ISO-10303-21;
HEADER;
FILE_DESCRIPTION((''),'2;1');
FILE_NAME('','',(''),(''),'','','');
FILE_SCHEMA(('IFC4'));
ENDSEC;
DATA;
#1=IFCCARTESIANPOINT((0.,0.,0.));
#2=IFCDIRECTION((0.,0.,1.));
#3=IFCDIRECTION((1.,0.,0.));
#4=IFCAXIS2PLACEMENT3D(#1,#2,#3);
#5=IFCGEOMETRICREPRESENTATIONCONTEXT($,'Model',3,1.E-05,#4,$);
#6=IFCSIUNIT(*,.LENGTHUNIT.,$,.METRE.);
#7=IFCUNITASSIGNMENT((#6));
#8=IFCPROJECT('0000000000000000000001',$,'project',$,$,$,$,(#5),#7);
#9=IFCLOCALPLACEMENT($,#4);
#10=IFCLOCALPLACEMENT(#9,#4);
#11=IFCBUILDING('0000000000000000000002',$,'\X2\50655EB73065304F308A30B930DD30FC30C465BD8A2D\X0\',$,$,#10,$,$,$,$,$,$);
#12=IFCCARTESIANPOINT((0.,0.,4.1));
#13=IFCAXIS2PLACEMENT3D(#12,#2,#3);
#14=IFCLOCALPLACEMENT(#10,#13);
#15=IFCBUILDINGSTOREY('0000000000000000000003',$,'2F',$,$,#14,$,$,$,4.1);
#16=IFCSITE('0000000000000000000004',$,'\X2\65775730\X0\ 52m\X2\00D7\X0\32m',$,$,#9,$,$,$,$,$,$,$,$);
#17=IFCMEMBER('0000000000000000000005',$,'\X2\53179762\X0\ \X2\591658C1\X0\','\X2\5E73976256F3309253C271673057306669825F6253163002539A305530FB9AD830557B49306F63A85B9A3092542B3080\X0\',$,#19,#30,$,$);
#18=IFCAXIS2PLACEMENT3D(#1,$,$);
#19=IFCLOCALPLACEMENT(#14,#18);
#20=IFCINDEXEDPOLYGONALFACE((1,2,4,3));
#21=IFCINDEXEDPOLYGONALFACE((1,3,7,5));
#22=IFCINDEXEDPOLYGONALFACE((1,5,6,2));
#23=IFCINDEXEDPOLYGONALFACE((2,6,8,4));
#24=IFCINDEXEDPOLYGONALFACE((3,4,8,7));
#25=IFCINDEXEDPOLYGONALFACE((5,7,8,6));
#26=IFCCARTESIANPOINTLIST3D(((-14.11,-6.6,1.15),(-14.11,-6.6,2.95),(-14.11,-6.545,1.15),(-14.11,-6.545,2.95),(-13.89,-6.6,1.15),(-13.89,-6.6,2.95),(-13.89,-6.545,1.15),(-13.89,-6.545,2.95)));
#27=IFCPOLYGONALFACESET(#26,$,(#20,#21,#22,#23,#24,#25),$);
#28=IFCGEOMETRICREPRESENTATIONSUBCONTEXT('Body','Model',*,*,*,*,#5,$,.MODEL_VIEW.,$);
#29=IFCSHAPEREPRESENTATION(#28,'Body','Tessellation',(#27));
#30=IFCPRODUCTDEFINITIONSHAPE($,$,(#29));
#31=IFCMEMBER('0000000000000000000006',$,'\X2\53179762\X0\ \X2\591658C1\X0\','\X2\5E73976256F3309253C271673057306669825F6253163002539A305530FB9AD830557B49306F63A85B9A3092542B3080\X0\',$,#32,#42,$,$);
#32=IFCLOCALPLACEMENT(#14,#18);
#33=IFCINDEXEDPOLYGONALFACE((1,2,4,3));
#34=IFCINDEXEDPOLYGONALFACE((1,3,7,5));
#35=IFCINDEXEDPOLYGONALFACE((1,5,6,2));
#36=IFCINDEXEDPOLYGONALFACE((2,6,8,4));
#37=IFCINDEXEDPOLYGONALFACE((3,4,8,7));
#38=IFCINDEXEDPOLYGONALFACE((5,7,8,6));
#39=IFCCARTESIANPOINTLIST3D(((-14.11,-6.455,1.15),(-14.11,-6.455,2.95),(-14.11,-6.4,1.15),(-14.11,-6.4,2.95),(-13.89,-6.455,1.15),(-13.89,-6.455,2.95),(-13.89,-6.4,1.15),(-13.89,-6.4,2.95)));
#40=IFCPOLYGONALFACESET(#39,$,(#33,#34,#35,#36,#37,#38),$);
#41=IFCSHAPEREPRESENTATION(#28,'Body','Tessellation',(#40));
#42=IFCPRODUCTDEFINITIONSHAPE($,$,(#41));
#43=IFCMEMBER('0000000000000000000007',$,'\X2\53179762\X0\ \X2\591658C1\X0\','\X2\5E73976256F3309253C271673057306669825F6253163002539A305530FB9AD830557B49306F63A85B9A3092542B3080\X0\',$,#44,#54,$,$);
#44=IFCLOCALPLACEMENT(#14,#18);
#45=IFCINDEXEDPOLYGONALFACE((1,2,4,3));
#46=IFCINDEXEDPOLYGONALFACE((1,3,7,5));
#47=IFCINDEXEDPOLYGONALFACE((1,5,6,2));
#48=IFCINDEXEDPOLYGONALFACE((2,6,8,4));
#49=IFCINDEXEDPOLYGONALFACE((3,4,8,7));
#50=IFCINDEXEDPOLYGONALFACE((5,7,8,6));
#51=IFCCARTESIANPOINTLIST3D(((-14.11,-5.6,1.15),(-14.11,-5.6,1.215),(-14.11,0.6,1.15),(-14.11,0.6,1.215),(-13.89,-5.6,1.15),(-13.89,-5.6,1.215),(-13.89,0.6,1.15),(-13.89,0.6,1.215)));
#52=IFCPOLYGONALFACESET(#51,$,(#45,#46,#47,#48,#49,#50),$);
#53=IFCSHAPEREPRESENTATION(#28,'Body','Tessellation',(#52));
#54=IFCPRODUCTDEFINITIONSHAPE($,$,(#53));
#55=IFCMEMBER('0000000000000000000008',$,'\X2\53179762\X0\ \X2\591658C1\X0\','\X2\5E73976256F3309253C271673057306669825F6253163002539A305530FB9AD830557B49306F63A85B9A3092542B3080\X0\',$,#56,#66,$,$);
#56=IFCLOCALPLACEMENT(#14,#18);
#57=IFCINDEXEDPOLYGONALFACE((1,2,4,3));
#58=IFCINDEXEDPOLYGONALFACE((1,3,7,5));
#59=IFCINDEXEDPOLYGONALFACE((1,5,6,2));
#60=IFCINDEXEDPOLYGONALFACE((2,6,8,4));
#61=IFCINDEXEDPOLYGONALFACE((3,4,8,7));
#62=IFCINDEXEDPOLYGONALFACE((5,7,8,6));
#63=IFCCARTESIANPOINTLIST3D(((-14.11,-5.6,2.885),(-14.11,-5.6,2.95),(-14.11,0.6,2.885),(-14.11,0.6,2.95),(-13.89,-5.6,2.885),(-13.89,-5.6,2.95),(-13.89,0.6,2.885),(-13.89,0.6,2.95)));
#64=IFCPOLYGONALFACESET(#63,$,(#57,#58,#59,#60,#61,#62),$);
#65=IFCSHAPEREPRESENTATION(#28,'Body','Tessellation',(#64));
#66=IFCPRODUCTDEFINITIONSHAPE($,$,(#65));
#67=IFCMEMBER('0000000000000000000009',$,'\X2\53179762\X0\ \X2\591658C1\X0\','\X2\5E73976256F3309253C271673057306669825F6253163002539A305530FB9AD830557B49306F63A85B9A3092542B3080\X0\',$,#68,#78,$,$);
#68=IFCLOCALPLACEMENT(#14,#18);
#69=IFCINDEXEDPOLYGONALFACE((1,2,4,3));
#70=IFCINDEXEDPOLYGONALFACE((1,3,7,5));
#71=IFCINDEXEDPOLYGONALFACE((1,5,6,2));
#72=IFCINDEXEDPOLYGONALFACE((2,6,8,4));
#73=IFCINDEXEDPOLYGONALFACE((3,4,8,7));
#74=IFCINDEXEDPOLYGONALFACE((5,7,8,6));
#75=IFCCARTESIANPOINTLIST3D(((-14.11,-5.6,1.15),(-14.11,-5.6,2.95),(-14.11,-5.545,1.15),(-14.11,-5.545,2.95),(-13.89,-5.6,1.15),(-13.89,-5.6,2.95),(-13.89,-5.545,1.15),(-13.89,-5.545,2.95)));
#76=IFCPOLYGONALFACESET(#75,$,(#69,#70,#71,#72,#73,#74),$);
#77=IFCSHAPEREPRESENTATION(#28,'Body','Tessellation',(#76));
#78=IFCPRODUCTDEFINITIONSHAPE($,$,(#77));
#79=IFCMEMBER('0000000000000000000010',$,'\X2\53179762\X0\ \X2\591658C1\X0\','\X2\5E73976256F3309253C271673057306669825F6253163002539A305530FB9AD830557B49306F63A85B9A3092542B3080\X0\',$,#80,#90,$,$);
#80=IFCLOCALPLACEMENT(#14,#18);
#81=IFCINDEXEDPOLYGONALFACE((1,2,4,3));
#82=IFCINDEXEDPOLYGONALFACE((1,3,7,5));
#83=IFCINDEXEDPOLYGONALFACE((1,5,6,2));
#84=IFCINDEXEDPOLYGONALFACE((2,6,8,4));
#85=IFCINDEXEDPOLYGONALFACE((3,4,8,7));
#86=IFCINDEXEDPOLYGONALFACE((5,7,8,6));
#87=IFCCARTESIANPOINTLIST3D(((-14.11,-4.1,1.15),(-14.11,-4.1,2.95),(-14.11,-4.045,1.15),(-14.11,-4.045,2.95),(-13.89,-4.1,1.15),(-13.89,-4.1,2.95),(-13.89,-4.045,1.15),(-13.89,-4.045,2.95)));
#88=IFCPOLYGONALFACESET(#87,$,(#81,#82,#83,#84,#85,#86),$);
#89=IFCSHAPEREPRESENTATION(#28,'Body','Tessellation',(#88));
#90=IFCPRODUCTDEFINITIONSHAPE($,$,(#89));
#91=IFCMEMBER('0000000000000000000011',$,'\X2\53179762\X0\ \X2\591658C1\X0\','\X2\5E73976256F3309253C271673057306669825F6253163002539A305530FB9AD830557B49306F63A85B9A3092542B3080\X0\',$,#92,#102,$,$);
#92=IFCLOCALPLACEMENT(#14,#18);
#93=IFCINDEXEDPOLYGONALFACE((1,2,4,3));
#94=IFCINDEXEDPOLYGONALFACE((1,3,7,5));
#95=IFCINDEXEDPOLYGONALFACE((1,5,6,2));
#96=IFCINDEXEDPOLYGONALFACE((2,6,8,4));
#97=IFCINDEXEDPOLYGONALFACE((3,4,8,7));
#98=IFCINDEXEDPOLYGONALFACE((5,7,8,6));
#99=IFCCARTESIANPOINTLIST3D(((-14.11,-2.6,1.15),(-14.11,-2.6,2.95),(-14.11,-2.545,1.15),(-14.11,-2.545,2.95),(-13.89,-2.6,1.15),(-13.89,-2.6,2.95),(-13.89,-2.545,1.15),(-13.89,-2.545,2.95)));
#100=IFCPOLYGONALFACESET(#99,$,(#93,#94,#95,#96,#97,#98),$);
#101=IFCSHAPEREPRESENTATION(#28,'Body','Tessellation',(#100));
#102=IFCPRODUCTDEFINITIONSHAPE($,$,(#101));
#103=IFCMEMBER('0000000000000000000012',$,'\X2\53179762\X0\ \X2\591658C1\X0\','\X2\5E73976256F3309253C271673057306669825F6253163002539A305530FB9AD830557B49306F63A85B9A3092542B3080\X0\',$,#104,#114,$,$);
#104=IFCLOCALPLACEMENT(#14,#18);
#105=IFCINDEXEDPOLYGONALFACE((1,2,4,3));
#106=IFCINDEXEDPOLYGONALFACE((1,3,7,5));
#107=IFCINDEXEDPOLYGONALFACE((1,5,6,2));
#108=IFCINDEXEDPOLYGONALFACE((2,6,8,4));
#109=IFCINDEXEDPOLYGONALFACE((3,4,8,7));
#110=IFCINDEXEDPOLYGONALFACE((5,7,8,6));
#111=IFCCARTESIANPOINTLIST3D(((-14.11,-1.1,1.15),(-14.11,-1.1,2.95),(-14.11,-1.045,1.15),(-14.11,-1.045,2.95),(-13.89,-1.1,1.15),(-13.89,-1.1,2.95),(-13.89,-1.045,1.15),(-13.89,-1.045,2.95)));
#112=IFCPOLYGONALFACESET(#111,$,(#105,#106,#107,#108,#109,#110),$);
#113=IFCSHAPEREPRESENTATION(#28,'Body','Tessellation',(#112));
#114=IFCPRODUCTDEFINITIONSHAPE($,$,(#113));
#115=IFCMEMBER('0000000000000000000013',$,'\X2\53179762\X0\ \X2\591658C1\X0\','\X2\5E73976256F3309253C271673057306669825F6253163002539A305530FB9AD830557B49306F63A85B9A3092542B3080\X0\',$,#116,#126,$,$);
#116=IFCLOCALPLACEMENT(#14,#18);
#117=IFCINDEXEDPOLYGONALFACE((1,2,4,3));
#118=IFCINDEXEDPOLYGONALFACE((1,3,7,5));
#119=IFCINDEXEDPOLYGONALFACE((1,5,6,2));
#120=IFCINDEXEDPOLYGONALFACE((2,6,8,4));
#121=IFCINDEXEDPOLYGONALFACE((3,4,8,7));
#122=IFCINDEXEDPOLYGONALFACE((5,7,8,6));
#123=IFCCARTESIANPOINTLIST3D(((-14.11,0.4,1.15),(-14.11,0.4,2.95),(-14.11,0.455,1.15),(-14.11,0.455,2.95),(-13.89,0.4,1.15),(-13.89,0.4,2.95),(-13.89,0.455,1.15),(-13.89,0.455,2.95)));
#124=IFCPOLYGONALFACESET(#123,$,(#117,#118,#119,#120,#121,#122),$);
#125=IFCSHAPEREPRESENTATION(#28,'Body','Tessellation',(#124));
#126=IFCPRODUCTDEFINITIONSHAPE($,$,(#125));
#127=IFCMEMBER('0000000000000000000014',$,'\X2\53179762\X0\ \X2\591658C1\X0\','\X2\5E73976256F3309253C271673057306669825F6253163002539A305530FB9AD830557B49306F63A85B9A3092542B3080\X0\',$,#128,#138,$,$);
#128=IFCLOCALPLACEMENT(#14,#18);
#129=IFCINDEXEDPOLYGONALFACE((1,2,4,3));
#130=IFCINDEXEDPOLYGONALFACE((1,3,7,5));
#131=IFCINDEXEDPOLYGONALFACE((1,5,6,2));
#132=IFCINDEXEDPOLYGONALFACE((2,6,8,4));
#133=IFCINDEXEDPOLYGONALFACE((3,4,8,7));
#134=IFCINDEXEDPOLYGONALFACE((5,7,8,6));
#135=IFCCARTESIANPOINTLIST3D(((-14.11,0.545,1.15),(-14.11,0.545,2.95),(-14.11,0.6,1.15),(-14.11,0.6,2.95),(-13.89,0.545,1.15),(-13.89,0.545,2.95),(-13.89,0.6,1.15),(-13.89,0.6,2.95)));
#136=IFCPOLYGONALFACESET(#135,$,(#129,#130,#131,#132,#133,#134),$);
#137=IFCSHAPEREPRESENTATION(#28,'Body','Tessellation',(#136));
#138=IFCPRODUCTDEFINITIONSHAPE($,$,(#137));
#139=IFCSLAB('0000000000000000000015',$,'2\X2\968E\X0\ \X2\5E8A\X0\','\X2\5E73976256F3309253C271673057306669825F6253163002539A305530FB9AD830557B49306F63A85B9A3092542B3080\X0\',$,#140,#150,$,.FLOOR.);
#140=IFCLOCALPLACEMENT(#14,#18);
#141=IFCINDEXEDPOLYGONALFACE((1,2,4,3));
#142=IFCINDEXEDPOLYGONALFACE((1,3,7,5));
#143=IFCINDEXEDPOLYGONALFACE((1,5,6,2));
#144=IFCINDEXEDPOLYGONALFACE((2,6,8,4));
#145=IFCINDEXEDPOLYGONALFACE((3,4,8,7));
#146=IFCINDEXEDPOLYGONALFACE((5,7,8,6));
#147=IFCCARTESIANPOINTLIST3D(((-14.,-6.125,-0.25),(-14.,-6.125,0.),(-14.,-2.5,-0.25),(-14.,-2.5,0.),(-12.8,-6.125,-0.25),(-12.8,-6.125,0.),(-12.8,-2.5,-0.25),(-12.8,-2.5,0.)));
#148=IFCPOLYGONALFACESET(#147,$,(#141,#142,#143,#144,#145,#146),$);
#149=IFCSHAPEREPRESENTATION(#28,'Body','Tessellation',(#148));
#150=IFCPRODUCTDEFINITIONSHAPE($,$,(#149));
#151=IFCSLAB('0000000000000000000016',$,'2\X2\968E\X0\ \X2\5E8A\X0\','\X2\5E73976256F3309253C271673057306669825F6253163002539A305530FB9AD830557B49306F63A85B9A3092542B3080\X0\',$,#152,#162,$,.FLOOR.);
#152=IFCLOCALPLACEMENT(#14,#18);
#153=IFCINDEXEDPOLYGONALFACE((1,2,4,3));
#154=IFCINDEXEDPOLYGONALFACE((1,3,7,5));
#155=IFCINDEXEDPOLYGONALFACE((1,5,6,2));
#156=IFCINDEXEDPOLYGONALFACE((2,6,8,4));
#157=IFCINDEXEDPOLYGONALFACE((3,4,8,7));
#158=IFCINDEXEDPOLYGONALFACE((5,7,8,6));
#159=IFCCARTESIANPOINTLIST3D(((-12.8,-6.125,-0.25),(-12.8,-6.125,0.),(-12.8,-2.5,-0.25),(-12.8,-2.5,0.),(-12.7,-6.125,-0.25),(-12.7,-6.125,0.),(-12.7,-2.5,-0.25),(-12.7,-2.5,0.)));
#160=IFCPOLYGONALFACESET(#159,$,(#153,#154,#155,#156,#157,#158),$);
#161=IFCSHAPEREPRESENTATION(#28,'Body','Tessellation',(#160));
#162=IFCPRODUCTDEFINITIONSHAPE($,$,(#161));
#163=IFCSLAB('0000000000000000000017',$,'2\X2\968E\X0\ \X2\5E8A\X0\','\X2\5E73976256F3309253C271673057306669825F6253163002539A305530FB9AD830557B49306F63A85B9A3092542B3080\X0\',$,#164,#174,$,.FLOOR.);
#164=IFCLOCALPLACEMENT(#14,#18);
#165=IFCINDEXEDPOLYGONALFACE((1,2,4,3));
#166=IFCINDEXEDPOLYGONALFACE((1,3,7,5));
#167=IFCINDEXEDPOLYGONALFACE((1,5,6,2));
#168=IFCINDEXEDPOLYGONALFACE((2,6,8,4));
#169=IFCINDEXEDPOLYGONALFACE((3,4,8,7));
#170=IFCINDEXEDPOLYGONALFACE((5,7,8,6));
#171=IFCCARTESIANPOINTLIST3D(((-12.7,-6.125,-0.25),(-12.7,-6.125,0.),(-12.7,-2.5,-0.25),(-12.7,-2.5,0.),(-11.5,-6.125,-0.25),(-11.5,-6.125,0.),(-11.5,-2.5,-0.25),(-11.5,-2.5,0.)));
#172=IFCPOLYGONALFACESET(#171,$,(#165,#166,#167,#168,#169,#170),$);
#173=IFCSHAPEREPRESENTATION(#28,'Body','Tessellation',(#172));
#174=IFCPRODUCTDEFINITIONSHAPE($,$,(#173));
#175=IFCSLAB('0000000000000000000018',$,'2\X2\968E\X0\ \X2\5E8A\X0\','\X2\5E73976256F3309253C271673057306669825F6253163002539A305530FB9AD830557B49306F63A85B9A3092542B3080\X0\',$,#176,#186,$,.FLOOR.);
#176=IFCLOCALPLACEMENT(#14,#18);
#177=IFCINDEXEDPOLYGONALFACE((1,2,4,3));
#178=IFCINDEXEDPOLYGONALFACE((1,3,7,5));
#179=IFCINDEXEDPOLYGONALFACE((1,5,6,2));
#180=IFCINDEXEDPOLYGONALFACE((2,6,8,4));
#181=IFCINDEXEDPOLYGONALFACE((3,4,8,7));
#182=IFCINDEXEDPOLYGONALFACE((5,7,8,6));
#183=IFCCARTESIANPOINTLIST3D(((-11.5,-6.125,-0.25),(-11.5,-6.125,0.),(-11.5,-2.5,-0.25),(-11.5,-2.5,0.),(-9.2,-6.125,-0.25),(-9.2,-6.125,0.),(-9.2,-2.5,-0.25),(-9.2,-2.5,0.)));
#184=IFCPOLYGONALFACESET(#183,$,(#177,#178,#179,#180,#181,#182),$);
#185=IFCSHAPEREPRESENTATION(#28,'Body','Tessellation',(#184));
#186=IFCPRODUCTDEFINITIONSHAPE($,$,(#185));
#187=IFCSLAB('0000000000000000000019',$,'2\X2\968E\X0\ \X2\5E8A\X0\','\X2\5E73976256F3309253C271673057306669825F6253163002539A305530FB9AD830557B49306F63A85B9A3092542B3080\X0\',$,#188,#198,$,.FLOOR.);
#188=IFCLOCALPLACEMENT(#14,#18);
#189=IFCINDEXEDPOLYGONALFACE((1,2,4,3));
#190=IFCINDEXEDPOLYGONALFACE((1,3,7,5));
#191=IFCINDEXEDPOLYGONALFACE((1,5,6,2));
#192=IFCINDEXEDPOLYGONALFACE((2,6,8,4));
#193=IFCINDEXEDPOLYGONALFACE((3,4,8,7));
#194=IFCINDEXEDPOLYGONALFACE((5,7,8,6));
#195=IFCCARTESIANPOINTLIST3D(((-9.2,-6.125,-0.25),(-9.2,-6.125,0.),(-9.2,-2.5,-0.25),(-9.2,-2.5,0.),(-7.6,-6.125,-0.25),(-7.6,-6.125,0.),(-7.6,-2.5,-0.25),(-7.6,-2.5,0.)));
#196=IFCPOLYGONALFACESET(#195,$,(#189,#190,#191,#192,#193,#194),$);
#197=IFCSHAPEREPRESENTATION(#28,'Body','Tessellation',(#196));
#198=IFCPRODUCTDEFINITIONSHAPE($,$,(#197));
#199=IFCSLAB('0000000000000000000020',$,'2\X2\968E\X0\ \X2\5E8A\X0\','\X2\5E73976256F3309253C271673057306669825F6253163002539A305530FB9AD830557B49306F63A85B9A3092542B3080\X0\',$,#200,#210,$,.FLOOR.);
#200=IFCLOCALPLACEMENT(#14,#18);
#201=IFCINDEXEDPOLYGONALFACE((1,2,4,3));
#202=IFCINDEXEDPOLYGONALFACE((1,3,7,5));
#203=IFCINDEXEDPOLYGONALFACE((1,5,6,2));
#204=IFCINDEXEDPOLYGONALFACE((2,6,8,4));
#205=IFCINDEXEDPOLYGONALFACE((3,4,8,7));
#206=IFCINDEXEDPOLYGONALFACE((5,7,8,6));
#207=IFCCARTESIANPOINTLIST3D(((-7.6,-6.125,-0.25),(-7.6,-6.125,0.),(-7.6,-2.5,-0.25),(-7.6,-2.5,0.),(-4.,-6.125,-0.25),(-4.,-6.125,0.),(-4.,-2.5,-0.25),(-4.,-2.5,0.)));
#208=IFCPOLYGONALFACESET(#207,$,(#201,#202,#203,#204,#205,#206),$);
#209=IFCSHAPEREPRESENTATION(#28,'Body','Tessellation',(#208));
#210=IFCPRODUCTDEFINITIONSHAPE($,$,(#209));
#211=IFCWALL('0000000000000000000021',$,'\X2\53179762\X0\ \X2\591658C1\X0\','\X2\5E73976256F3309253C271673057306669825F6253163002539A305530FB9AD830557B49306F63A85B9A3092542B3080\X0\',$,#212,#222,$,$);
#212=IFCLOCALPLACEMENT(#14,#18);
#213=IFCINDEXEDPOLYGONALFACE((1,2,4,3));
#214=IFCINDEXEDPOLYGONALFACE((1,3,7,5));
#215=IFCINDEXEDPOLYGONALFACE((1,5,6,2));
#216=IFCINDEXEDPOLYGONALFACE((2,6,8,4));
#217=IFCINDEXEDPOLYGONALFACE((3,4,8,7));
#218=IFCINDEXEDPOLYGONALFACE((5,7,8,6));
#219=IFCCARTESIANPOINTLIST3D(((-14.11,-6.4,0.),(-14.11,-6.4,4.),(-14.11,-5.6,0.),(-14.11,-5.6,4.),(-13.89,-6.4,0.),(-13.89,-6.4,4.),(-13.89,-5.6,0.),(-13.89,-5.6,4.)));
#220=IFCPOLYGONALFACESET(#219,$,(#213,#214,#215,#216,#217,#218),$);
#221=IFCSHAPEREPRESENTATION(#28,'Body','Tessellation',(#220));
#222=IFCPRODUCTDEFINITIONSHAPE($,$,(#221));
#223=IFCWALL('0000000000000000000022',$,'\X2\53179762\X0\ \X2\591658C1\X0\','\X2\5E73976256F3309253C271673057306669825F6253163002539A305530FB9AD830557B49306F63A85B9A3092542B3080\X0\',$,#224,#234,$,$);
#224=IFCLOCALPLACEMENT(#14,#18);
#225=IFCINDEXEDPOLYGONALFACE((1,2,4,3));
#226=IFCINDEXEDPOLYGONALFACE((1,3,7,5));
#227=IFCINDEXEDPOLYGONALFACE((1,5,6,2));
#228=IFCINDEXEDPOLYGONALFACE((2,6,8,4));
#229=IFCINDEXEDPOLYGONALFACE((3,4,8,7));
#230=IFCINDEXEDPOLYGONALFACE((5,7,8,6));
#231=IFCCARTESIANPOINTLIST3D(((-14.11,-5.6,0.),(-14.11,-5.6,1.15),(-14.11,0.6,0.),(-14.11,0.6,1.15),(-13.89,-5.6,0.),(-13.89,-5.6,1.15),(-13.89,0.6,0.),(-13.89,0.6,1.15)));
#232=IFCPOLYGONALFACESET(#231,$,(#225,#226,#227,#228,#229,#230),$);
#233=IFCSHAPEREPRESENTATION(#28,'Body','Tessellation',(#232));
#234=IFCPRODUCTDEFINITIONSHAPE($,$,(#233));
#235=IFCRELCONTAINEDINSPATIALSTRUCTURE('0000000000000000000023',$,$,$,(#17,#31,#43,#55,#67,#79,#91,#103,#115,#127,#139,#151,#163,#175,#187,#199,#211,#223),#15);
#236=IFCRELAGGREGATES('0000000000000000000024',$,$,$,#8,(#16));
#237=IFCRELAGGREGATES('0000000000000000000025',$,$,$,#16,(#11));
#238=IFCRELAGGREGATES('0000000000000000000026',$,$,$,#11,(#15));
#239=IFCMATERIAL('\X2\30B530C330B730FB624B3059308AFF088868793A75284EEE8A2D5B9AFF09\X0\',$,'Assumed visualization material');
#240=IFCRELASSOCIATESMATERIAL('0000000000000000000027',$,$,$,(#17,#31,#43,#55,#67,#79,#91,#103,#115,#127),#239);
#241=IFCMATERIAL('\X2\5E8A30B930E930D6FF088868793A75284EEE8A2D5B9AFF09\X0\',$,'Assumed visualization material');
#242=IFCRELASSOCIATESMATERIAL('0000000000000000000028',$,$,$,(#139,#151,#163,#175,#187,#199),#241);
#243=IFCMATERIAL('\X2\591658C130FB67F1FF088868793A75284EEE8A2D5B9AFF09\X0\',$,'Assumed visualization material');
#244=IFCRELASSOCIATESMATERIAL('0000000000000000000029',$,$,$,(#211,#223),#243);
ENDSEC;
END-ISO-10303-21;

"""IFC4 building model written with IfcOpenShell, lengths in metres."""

from ifc_helpers import new_model, si_unit, frame, origin_with_axes, place, context, subcontext, project, spatial, rectangle, extrude, material, element, save


model = new_model("IFC4")

# Units and contexts
model_context = context("Model", 3, precision=1e-05, world=origin_with_axes())
body_context = subcontext(model_context, "Body", "Model", "MODEL_VIEW")
ifc_project = project(units=[si_unit("LENGTHUNIT", "METRE")], contexts=[model_context])

# Site, building, storey
site_placement = place(None, origin_with_axes())
site = spatial("IfcSite", under=ifc_project, at=site_placement, Name="敷地 52m×32m")
building_placement = place(site_placement, origin_with_axes())
building = spatial("IfcBuilding", under=site, at=building_placement, Name="健康づくりスポーツ施設")
storey_placement = place(building_placement, frame((0.0, 0.0, 4.1), z_axis=(0.0, 0.0, 1.0), x_axis=(1.0, 0.0, 0.0)))
storey = spatial("IfcBuildingStorey", under=building, at=storey_placement, Name="2F", Elevation=4.1)

# Members
ifc_material_1 = material(Name="サッシ・手すり（表示用仮設定）", Category="Assumed visualization material")
for number, where, z_axis, x_axis, name in (
    (1, (-14.0, -6.5725, 1.15), (0.0, 0.0, 1.0), (1.0, 0.0, 0.0), "北面 外壁"),
    (2, (-14.0, -6.4275, 1.15), (0.0, 0.0, 1.0), (1.0, 0.0, 0.0), "北面 外壁"),
):
    element("IfcMember", number, at=place(storey_placement, frame(where, z_axis=z_axis, x_axis=x_axis)), inside=storey, material=ifc_material_1, Name=name, Description="平面図を参照して概形化。厚さ・高さ等は推定を含む", context=body_context, shape_type="SweptSolid", body=[
        extrude(rectangle(XDim=0.22, YDim=0.055), origin_with_axes(), (0.0, 0.0, 1.0), 1.8),
    ])
for number, where, z_axis, x_axis, name in (
    (3, (-14.0, -2.5, 1.15), (0.0, 0.0, 1.0), (1.0, 0.0, 0.0), "北面 外壁"),
    (4, (-14.0, -2.5, 2.885), (0.0, 0.0, 1.0), (1.0, 0.0, 0.0), "北面 外壁"),
):
    element("IfcMember", number, at=place(storey_placement, frame(where, z_axis=z_axis, x_axis=x_axis)), inside=storey, material=ifc_material_1, Name=name, Description="平面図を参照して概形化。厚さ・高さ等は推定を含む", context=body_context, shape_type="SweptSolid", body=[
        extrude(rectangle(XDim=0.22, YDim=6.2), origin_with_axes(), (0.0, 0.0, 1.0), 0.065),
    ])
for number, where, z_axis, x_axis, name in (
    (5, (-14.0, -5.5725, 1.15), (0.0, 0.0, 1.0), (1.0, 0.0, 0.0), "北面 外壁"),
    (6, (-14.0, -4.0725, 1.15), (0.0, 0.0, 1.0), (1.0, 0.0, 0.0), "北面 外壁"),
    (7, (-14.0, -2.5725, 1.15), (0.0, 0.0, 1.0), (1.0, 0.0, 0.0), "北面 外壁"),
    (8, (-14.0, -1.0725, 1.15), (0.0, 0.0, 1.0), (1.0, 0.0, 0.0), "北面 外壁"),
    (9, (-14.0, 0.4275, 1.15), (0.0, 0.0, 1.0), (1.0, 0.0, 0.0), "北面 外壁"),
    (10, (-14.0, 0.5725, 1.15), (0.0, 0.0, 1.0), (1.0, 0.0, 0.0), "北面 外壁"),
):
    element("IfcMember", number, at=place(storey_placement, frame(where, z_axis=z_axis, x_axis=x_axis)), inside=storey, material=ifc_material_1, Name=name, Description="平面図を参照して概形化。厚さ・高さ等は推定を含む", context=body_context, shape_type="SweptSolid", body=[
        extrude(rectangle(XDim=0.22, YDim=0.055), origin_with_axes(), (0.0, 0.0, 1.0), 1.8),
    ])

# Slabs
ifc_material_2 = material(Name="床スラブ（表示用仮設定）", Category="Assumed visualization material")
slab_1_placement = place(storey_placement, frame((-13.4, -4.3125, -0.25), z_axis=(0.0, 0.0, 1.0), x_axis=(1.0, 0.0, 0.0)))
element("IfcSlab", 11, at=slab_1_placement, inside=storey, material=ifc_material_2, Name="2階 床", Description="平面図を参照して概形化。厚さ・高さ等は推定を含む", PredefinedType="FLOOR", context=body_context, shape_type="SweptSolid", body=[
    extrude(rectangle(XDim=1.2, YDim=3.625), origin_with_axes(), (0.0, 0.0, 1.0), 0.25),
])
slab_2_placement = place(storey_placement, frame((-12.75, -4.3125, -0.25), z_axis=(0.0, 0.0, 1.0), x_axis=(1.0, 0.0, 0.0)))
element("IfcSlab", 12, at=slab_2_placement, inside=storey, material=ifc_material_2, Name="2階 床", Description="平面図を参照して概形化。厚さ・高さ等は推定を含む", PredefinedType="FLOOR", context=body_context, shape_type="SweptSolid", body=[
    extrude(rectangle(XDim=0.1, YDim=3.625), origin_with_axes(), (0.0, 0.0, 1.0), 0.25),
])
slab_3_placement = place(storey_placement, frame((-12.1, -4.3125, -0.25), z_axis=(0.0, 0.0, 1.0), x_axis=(1.0, 0.0, 0.0)))
element("IfcSlab", 13, at=slab_3_placement, inside=storey, material=ifc_material_2, Name="2階 床", Description="平面図を参照して概形化。厚さ・高さ等は推定を含む", PredefinedType="FLOOR", context=body_context, shape_type="SweptSolid", body=[
    extrude(rectangle(XDim=1.2, YDim=3.625), origin_with_axes(), (0.0, 0.0, 1.0), 0.25),
])
slab_4_placement = place(storey_placement, frame((-10.35, -4.3125, -0.25), z_axis=(0.0, 0.0, 1.0), x_axis=(1.0, 0.0, 0.0)))
element("IfcSlab", 14, at=slab_4_placement, inside=storey, material=ifc_material_2, Name="2階 床", Description="平面図を参照して概形化。厚さ・高さ等は推定を含む", PredefinedType="FLOOR", context=body_context, shape_type="SweptSolid", body=[
    extrude(rectangle(XDim=2.3, YDim=3.625), origin_with_axes(), (0.0, 0.0, 1.0), 0.25),
])
slab_5_placement = place(storey_placement, frame((-8.4, -4.3125, -0.25), z_axis=(0.0, 0.0, 1.0), x_axis=(1.0, 0.0, 0.0)))
element("IfcSlab", 15, at=slab_5_placement, inside=storey, material=ifc_material_2, Name="2階 床", Description="平面図を参照して概形化。厚さ・高さ等は推定を含む", PredefinedType="FLOOR", context=body_context, shape_type="SweptSolid", body=[
    extrude(rectangle(XDim=1.6, YDim=3.625), origin_with_axes(), (0.0, 0.0, 1.0), 0.25),
])
slab_6_placement = place(storey_placement, frame((-5.8, -4.3125, -0.25), z_axis=(0.0, 0.0, 1.0), x_axis=(1.0, 0.0, 0.0)))
element("IfcSlab", 16, at=slab_6_placement, inside=storey, material=ifc_material_2, Name="2階 床", Description="平面図を参照して概形化。厚さ・高さ等は推定を含む", PredefinedType="FLOOR", context=body_context, shape_type="SweptSolid", body=[
    extrude(rectangle(XDim=3.6, YDim=3.625), origin_with_axes(), (0.0, 0.0, 1.0), 0.25),
])

# Walls
ifc_material_3 = material(Name="外壁・柱（表示用仮設定）", Category="Assumed visualization material")
wall_1_placement = place(storey_placement, frame((-14.0, -6.0, 0.0), z_axis=(0.0, 0.0, 1.0), x_axis=(1.0, 0.0, 0.0)))
element("IfcWall", 17, at=wall_1_placement, inside=storey, material=ifc_material_3, Name="北面 外壁", Description="平面図を参照して概形化。厚さ・高さ等は推定を含む", context=body_context, shape_type="SweptSolid", body=[
    extrude(rectangle(XDim=0.22, YDim=0.8), origin_with_axes(), (0.0, 0.0, 1.0), 4.0),
])
wall_2_placement = place(storey_placement, frame((-14.0, -2.5, 0.0), z_axis=(0.0, 0.0, 1.0), x_axis=(1.0, 0.0, 0.0)))
element("IfcWall", 18, at=wall_2_placement, inside=storey, material=ifc_material_3, Name="北面 外壁", Description="平面図を参照して概形化。厚さ・高さ等は推定を含む", context=body_context, shape_type="SweptSolid", body=[
    extrude(rectangle(XDim=0.22, YDim=6.2), origin_with_axes(), (0.0, 0.0, 1.0), 1.15),
])

save(model, "model.ifc")
